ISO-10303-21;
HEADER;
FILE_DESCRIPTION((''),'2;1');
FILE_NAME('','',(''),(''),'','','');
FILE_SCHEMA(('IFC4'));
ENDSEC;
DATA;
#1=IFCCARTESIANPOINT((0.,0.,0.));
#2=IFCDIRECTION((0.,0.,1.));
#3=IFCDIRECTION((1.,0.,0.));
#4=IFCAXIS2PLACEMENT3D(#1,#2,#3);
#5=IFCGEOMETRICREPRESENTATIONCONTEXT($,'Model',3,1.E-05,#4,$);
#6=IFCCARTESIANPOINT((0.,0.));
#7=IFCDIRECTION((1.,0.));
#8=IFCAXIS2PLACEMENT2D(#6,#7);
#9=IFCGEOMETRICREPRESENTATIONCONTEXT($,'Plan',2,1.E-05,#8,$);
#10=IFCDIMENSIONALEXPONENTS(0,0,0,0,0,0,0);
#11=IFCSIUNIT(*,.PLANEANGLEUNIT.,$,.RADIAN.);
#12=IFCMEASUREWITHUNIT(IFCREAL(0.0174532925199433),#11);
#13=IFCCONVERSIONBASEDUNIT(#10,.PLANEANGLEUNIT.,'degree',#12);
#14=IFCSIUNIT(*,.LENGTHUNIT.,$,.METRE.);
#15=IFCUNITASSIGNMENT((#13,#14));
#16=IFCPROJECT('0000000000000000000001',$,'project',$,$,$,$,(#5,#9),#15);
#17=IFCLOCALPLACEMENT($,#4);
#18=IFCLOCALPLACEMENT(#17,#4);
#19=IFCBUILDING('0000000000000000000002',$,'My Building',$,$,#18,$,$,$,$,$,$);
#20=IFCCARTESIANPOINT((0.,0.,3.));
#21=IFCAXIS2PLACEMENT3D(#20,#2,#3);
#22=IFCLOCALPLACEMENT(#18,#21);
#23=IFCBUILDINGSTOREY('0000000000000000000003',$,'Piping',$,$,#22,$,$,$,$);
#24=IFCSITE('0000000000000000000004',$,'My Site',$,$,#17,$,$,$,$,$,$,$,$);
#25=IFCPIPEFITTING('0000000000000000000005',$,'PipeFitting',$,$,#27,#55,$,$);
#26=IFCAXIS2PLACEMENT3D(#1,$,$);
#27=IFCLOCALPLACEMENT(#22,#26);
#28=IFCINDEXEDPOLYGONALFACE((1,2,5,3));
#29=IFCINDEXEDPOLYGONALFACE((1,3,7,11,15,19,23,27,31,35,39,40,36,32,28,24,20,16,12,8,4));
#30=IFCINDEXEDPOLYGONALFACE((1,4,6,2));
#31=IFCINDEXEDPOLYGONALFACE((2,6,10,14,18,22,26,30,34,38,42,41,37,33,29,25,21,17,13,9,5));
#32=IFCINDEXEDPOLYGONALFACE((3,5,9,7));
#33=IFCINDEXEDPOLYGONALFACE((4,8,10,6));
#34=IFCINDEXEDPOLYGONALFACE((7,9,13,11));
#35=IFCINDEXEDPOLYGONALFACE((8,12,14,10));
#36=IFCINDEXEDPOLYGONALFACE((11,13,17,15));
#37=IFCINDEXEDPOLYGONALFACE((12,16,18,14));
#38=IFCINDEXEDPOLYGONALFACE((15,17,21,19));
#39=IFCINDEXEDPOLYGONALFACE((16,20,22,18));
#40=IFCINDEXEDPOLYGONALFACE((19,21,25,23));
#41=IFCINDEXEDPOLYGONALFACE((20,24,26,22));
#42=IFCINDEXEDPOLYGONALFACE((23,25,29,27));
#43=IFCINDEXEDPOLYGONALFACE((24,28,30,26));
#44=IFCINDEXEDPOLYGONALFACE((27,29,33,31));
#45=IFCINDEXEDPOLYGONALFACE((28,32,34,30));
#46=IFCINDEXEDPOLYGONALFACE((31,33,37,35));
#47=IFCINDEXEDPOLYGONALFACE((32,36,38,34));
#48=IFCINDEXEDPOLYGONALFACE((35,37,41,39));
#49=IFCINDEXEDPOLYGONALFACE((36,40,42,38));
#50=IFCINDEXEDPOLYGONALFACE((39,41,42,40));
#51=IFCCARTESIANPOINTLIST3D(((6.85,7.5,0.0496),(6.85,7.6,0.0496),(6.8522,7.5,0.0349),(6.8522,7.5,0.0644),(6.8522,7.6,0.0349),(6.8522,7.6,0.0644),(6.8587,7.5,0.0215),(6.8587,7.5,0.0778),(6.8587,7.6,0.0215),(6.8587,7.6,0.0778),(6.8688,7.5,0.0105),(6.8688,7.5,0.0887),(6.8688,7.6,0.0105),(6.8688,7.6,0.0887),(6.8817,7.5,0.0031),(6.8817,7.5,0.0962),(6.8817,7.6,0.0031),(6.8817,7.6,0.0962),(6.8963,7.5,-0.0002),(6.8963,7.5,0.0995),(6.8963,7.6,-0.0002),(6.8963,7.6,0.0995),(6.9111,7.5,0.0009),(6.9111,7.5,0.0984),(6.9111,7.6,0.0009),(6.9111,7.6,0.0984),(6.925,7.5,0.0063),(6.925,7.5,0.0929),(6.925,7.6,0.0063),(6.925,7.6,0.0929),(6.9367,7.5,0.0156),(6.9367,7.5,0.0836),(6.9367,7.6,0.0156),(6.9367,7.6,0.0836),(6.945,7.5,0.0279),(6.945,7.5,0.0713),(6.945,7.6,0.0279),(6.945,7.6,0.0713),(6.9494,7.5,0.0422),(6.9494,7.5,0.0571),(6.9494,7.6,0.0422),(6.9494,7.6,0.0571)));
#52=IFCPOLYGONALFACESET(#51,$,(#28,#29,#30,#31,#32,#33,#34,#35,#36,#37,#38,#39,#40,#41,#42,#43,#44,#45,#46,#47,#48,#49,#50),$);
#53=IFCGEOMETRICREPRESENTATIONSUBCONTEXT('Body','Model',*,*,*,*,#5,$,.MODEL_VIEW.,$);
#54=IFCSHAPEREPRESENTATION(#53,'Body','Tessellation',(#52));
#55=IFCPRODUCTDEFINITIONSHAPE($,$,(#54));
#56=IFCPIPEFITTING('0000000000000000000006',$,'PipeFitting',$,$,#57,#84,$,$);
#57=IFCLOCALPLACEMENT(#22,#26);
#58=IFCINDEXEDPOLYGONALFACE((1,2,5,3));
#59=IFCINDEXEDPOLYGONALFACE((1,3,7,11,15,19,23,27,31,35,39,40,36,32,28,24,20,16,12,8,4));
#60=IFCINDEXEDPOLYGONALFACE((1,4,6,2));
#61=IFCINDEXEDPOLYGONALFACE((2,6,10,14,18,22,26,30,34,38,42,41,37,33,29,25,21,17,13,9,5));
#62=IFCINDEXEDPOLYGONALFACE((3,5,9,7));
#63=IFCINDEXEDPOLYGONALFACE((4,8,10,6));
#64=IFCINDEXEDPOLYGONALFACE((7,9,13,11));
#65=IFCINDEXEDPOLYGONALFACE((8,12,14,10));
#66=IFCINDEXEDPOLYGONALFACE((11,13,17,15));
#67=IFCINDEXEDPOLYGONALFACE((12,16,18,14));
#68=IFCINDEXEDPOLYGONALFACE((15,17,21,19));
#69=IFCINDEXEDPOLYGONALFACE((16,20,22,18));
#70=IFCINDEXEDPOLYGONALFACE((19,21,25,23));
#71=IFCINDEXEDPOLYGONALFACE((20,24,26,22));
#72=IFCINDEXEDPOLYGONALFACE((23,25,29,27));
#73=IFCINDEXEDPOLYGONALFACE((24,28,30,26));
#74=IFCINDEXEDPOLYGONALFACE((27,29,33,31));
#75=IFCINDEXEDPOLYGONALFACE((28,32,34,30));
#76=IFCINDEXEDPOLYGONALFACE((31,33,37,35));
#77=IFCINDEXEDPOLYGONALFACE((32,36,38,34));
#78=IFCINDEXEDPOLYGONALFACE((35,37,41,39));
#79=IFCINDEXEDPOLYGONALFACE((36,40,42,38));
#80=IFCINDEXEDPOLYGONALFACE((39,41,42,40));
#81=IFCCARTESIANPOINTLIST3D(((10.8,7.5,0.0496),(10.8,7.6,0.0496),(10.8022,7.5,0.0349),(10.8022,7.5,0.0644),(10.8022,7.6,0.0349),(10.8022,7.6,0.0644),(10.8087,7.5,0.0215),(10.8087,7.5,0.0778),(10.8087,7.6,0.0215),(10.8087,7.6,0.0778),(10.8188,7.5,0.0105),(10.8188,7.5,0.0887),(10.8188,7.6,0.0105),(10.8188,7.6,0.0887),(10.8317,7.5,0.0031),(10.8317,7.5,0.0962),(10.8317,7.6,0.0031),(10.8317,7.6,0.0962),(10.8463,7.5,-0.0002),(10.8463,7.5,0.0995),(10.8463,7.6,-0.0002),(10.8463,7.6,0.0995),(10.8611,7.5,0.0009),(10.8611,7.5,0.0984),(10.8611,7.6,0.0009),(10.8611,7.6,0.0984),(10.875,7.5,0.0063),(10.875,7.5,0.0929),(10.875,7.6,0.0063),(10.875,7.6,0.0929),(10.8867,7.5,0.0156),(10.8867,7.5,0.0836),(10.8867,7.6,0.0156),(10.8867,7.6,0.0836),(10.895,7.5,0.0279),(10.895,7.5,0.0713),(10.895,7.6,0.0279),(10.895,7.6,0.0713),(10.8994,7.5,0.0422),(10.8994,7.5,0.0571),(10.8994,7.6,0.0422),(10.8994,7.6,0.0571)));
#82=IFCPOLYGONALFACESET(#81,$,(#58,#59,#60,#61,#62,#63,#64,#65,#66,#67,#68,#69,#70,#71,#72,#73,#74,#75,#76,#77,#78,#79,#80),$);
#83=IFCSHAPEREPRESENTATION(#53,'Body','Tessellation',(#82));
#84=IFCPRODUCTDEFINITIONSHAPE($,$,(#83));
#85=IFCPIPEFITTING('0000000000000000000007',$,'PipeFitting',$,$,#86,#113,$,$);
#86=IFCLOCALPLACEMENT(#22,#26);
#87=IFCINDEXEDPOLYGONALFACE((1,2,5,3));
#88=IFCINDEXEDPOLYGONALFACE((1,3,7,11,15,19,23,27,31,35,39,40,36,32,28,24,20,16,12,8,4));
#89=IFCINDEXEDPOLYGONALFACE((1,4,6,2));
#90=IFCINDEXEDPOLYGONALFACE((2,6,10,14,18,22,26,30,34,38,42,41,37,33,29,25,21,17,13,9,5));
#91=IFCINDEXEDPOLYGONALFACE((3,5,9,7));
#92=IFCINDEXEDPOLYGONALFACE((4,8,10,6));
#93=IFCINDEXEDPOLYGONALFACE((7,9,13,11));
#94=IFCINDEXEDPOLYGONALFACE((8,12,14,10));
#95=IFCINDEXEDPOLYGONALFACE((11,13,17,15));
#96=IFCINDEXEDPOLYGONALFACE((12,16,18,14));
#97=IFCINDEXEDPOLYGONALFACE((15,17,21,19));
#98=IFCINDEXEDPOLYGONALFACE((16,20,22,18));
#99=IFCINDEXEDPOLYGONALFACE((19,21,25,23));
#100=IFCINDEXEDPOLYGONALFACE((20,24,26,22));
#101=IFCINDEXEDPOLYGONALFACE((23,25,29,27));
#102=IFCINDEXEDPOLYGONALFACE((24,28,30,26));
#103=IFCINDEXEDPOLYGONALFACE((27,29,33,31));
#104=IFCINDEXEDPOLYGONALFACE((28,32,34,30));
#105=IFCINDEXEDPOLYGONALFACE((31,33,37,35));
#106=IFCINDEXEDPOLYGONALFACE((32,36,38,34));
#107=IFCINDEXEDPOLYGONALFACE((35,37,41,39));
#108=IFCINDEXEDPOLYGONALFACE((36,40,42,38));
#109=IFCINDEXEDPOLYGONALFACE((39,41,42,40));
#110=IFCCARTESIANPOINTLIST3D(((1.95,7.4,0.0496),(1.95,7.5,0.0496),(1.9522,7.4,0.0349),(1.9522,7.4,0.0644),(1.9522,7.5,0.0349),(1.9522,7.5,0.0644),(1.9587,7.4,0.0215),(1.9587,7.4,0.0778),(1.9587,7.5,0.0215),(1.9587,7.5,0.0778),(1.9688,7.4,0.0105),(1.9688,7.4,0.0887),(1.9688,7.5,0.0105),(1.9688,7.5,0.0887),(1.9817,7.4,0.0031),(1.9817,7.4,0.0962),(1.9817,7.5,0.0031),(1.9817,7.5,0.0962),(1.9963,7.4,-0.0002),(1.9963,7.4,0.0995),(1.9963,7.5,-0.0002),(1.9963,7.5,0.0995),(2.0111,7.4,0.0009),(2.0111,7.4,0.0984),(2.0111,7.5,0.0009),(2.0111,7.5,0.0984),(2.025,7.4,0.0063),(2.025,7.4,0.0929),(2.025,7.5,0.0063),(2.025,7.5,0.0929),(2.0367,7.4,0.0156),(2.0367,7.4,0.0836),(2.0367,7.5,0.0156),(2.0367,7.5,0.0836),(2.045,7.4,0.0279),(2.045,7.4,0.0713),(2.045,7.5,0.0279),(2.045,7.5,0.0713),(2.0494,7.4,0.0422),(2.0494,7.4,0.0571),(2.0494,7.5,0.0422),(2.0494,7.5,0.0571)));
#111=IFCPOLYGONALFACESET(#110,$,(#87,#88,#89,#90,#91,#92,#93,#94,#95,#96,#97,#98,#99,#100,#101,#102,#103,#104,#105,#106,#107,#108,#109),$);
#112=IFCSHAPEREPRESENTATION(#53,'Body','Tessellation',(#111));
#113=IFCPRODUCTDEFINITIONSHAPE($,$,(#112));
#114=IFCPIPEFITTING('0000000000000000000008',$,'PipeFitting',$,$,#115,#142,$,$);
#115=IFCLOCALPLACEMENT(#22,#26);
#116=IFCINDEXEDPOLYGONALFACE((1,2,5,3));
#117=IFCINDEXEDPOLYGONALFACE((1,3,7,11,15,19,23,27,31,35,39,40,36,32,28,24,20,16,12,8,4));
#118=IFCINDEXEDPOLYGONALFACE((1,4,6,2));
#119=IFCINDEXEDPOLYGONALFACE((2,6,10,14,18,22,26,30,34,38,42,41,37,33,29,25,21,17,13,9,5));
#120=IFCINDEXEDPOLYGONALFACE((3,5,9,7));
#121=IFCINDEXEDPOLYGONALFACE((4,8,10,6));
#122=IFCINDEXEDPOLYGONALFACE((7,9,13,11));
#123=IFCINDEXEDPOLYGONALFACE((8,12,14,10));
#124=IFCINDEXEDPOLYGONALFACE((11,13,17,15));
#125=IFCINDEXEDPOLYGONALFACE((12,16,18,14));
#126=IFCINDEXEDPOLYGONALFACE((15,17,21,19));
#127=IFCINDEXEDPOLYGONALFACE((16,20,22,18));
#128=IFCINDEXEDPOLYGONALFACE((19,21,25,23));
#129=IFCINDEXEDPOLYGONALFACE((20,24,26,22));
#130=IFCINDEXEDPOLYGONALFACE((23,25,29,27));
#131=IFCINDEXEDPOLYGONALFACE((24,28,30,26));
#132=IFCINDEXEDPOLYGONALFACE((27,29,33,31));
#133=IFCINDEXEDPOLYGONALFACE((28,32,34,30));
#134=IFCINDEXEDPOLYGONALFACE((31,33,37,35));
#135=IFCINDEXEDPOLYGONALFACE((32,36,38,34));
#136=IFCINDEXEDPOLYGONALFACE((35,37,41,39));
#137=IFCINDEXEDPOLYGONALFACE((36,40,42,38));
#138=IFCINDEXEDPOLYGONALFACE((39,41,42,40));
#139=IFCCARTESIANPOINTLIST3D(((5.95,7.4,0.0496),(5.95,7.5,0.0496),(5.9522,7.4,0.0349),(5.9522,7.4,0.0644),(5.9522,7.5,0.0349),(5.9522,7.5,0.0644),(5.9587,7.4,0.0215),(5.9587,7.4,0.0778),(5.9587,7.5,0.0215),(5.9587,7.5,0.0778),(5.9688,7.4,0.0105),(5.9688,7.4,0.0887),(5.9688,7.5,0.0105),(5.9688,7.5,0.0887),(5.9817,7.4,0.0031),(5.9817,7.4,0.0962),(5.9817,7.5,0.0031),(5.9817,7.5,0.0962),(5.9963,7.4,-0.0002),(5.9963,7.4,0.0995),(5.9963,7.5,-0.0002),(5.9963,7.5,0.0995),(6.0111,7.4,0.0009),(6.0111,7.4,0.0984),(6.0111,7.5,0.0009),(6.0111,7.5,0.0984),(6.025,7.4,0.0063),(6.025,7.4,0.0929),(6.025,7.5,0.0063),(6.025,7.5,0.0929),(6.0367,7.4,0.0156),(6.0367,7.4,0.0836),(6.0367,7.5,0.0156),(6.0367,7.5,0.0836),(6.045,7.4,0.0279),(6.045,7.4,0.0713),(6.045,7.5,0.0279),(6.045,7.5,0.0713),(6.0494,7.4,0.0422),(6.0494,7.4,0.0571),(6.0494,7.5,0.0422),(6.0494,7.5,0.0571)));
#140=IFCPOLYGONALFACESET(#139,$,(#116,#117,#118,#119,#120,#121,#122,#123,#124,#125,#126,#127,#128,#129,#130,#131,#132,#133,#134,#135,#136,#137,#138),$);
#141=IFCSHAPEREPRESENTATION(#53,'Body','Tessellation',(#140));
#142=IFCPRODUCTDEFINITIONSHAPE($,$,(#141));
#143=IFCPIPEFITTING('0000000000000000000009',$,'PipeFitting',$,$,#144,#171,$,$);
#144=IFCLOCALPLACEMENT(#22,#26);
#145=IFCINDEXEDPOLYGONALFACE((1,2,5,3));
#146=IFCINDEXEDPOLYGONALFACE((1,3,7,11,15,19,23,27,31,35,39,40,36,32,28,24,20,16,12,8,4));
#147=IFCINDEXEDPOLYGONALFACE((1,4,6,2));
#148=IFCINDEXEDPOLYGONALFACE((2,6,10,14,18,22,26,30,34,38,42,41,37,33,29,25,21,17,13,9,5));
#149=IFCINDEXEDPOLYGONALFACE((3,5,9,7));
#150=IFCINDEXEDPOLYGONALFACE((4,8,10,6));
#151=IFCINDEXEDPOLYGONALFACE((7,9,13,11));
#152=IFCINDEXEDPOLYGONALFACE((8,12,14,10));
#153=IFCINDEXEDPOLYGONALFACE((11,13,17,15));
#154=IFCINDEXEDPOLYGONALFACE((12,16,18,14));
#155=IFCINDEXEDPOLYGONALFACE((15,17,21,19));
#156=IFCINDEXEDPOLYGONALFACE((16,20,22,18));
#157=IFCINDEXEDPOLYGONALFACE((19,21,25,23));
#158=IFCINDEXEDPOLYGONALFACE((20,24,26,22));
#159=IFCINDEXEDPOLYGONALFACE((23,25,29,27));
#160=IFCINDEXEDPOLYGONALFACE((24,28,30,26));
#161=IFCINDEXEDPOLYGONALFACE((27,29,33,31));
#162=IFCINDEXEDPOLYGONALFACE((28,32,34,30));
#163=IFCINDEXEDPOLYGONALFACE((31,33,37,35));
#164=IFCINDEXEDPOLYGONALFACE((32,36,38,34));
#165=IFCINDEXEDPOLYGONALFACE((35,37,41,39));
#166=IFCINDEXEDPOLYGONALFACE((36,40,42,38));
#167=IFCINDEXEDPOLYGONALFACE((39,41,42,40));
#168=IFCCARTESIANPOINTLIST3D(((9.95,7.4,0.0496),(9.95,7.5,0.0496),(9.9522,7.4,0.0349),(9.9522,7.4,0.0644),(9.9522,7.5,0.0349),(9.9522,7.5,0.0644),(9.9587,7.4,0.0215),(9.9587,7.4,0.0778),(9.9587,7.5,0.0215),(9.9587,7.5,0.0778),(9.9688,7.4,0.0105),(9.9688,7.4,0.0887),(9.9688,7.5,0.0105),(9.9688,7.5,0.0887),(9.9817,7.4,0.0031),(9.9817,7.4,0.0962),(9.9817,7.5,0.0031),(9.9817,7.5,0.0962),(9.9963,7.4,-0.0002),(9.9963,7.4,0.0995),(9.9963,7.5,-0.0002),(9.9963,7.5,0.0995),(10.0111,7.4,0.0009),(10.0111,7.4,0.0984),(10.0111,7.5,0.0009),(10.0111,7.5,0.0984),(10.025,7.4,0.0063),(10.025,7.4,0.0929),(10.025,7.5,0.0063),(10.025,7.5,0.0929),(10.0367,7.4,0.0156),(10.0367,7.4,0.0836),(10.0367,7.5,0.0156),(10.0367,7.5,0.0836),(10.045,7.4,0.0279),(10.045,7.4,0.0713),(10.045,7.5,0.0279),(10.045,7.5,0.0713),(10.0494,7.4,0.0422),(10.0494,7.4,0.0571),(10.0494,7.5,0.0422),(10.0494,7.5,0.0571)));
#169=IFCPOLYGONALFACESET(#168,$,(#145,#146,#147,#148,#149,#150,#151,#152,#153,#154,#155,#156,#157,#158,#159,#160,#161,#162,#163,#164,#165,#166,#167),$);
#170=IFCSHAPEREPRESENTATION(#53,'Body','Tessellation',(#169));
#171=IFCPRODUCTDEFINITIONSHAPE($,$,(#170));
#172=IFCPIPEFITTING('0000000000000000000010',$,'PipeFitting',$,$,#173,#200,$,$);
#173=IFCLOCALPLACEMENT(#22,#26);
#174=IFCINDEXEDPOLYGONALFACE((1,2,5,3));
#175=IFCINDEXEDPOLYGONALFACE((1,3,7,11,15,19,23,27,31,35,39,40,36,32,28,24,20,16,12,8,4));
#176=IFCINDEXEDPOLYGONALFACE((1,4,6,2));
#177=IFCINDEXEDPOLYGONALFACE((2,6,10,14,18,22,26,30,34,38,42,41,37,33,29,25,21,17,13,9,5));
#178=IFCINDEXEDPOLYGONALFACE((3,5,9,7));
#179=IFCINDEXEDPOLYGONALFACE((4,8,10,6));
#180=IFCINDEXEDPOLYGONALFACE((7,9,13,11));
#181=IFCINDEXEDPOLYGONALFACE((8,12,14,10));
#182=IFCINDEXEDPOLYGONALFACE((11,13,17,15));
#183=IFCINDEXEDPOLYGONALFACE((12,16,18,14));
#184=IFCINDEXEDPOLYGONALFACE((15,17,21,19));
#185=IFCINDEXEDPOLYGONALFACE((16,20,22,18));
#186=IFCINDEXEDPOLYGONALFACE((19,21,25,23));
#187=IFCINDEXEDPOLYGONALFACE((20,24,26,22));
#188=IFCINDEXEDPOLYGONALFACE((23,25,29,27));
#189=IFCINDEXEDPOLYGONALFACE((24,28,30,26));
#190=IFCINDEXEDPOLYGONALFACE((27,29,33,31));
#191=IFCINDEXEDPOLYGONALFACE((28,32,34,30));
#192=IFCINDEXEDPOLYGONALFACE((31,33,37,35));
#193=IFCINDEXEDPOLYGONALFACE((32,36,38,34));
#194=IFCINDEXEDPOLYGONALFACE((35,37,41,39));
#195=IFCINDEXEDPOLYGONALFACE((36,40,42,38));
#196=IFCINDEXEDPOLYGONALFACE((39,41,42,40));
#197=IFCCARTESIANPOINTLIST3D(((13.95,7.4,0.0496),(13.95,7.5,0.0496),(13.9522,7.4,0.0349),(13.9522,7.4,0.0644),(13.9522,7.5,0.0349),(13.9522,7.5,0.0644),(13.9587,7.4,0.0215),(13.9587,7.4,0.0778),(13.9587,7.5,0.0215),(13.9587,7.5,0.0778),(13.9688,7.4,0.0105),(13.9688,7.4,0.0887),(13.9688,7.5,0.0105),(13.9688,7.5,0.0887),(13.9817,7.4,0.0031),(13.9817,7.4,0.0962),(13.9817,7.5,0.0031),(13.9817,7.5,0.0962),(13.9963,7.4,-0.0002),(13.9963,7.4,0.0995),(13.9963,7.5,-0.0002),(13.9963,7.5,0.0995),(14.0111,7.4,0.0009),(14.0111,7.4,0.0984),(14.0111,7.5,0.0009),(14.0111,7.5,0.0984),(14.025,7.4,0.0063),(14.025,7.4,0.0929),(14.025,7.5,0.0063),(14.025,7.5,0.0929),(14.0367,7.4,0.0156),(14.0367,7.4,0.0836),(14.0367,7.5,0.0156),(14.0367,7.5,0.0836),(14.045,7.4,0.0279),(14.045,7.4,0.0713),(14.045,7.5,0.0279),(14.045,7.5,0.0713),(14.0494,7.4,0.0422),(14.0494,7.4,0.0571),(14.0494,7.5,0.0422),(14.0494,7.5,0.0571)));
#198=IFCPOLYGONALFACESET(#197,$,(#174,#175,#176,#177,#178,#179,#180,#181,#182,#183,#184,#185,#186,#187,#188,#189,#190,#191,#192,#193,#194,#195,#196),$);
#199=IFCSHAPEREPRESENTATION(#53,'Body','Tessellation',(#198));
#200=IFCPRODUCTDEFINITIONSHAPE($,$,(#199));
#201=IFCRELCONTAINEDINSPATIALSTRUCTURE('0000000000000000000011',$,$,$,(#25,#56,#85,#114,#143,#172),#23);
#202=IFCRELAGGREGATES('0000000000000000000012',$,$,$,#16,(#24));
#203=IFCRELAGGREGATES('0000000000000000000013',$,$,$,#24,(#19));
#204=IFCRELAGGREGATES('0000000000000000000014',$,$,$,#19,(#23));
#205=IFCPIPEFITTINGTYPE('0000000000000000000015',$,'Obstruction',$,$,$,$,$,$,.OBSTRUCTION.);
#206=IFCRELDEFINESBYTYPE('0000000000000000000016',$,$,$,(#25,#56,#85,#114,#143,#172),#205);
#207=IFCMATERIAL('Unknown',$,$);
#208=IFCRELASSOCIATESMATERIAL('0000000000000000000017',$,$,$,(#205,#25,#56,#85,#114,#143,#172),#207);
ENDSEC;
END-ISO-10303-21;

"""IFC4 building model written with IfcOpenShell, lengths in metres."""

from ifc_helpers import new_model, entity, si_unit, converted_unit, frame, origin_with_axes, origin_2d_with_axis, place, context, subcontext, project, spatial, circle, extrude, material, material_profile, profile_set, profile_usage, type_object, element, save


model = new_model("IFC4")

# Units and contexts
model_context = context("Model", 3, precision=1e-05, world=origin_with_axes())
plan_context = context("Plan", 2, precision=1e-05, world=origin_2d_with_axis())
body_context = subcontext(model_context, "Body", "Model", "MODEL_VIEW")
ifc_project = project(units=[converted_unit("PLANEANGLEUNIT", "degree", entity("IfcReal", 0.0174532925199433), si_unit("PLANEANGLEUNIT", "RADIAN"), dimensions=[0, 0, 0, 0, 0, 0, 0]), si_unit("LENGTHUNIT", "METRE")], contexts=[model_context, plan_context])

# Site, building, storey
site_placement = place(None, origin_with_axes())
site = spatial("IfcSite", under=ifc_project, at=site_placement, Name="My Site")
building_placement = place(site_placement, origin_with_axes())
building = spatial("IfcBuilding", under=site, at=building_placement, Name="My Building")
storey_placement = place(building_placement, frame((0.0, 0.0, 3.0), z_axis=(0.0, 0.0, 1.0), x_axis=(1.0, 0.0, 0.0)))
storey = spatial("IfcBuildingStorey", under=building, at=storey_placement, Name="Piping")

# Shared definitions
ifc_material = material(Name="Unknown")

# Pipe fittings
ifc_material_profile_1 = material_profile(ifc_material, circle(Radius=0.05))
ifc_profile_set_1 = profile_set([ifc_material_profile_1])
pipe_fitting_type_1 = type_object("IfcPipeFittingType", Name="Obstruction", PredefinedType="OBSTRUCTION", material=ifc_profile_set_1)
ifc_profile_usage_1 = profile_usage(ifc_profile_set_1, cardinal=5)
pipe_fitting_1_placement = place(storey_placement, frame((6.9, 7.5, 0.0496), z_axis=(0.0, 1.0, 0.0), x_axis=(-1.0, 0.0, 0.0)))
element("IfcPipeFitting", 1, at=pipe_fitting_1_placement, inside=storey, type_object=pipe_fitting_type_1, material=ifc_profile_usage_1, Name="PipeFitting", context=body_context, shape_type="SweptSolid", body=[
    extrude(circle(Radius=0.05), origin_with_axes(), (0.0, 0.0, 1.0), 0.1),
])
ifc_profile_usage_2 = profile_usage(ifc_profile_set_1, cardinal=5)
pipe_fitting_2_placement = place(storey_placement, frame((10.85, 7.5, 0.0496), z_axis=(0.0, 1.0, 0.0), x_axis=(-1.0, 0.0, 0.0)))
element("IfcPipeFitting", 2, at=pipe_fitting_2_placement, inside=storey, type_object=pipe_fitting_type_1, material=ifc_profile_usage_2, Name="PipeFitting", context=body_context, shape_type="SweptSolid", body=[
    extrude(circle(Radius=0.05), origin_with_axes(), (0.0, 0.0, 1.0), 0.1),
])
ifc_profile_usage_3 = profile_usage(ifc_profile_set_1, cardinal=5)
pipe_fitting_3_placement = place(storey_placement, frame((2.0, 7.4, 0.0496), z_axis=(0.0, 1.0, 0.0), x_axis=(-1.0, 0.0, 0.0)))
element("IfcPipeFitting", 3, at=pipe_fitting_3_placement, inside=storey, type_object=pipe_fitting_type_1, material=ifc_profile_usage_3, Name="PipeFitting", context=body_context, shape_type="SweptSolid", body=[
    extrude(circle(Radius=0.05), origin_with_axes(), (0.0, 0.0, 1.0), 0.1),
])
ifc_profile_usage_4 = profile_usage(ifc_profile_set_1, cardinal=5)
pipe_fitting_4_placement = place(storey_placement, frame((6.0, 7.4, 0.0496), z_axis=(0.0, 1.0, 0.0), x_axis=(-1.0, 0.0, 0.0)))
element("IfcPipeFitting", 4, at=pipe_fitting_4_placement, inside=storey, type_object=pipe_fitting_type_1, material=ifc_profile_usage_4, Name="PipeFitting", context=body_context, shape_type="SweptSolid", body=[
    extrude(circle(Radius=0.05), origin_with_axes(), (0.0, 0.0, 1.0), 0.1),
])
ifc_profile_usage_5 = profile_usage(ifc_profile_set_1, cardinal=5)
pipe_fitting_5_placement = place(storey_placement, frame((10.0, 7.4, 0.0496), z_axis=(0.0, 1.0, 0.0), x_axis=(-1.0, 0.0, 0.0)))
element("IfcPipeFitting", 5, at=pipe_fitting_5_placement, inside=storey, type_object=pipe_fitting_type_1, material=ifc_profile_usage_5, Name="PipeFitting", context=body_context, shape_type="SweptSolid", body=[
    extrude(circle(Radius=0.05), origin_with_axes(), (0.0, 0.0, 1.0), 0.1),
])
ifc_profile_usage_6 = profile_usage(ifc_profile_set_1, cardinal=5)
pipe_fitting_6_placement = place(storey_placement, frame((14.0, 7.4, 0.0496), z_axis=(0.0, 1.0, 0.0), x_axis=(-1.0, 0.0, 0.0)))
element("IfcPipeFitting", 6, at=pipe_fitting_6_placement, inside=storey, type_object=pipe_fitting_type_1, material=ifc_profile_usage_6, Name="PipeFitting", context=body_context, shape_type="SweptSolid", body=[
    extrude(circle(Radius=0.05), origin_with_axes(), (0.0, 0.0, 1.0), 0.1),
])

save(model, "model.ifc")
